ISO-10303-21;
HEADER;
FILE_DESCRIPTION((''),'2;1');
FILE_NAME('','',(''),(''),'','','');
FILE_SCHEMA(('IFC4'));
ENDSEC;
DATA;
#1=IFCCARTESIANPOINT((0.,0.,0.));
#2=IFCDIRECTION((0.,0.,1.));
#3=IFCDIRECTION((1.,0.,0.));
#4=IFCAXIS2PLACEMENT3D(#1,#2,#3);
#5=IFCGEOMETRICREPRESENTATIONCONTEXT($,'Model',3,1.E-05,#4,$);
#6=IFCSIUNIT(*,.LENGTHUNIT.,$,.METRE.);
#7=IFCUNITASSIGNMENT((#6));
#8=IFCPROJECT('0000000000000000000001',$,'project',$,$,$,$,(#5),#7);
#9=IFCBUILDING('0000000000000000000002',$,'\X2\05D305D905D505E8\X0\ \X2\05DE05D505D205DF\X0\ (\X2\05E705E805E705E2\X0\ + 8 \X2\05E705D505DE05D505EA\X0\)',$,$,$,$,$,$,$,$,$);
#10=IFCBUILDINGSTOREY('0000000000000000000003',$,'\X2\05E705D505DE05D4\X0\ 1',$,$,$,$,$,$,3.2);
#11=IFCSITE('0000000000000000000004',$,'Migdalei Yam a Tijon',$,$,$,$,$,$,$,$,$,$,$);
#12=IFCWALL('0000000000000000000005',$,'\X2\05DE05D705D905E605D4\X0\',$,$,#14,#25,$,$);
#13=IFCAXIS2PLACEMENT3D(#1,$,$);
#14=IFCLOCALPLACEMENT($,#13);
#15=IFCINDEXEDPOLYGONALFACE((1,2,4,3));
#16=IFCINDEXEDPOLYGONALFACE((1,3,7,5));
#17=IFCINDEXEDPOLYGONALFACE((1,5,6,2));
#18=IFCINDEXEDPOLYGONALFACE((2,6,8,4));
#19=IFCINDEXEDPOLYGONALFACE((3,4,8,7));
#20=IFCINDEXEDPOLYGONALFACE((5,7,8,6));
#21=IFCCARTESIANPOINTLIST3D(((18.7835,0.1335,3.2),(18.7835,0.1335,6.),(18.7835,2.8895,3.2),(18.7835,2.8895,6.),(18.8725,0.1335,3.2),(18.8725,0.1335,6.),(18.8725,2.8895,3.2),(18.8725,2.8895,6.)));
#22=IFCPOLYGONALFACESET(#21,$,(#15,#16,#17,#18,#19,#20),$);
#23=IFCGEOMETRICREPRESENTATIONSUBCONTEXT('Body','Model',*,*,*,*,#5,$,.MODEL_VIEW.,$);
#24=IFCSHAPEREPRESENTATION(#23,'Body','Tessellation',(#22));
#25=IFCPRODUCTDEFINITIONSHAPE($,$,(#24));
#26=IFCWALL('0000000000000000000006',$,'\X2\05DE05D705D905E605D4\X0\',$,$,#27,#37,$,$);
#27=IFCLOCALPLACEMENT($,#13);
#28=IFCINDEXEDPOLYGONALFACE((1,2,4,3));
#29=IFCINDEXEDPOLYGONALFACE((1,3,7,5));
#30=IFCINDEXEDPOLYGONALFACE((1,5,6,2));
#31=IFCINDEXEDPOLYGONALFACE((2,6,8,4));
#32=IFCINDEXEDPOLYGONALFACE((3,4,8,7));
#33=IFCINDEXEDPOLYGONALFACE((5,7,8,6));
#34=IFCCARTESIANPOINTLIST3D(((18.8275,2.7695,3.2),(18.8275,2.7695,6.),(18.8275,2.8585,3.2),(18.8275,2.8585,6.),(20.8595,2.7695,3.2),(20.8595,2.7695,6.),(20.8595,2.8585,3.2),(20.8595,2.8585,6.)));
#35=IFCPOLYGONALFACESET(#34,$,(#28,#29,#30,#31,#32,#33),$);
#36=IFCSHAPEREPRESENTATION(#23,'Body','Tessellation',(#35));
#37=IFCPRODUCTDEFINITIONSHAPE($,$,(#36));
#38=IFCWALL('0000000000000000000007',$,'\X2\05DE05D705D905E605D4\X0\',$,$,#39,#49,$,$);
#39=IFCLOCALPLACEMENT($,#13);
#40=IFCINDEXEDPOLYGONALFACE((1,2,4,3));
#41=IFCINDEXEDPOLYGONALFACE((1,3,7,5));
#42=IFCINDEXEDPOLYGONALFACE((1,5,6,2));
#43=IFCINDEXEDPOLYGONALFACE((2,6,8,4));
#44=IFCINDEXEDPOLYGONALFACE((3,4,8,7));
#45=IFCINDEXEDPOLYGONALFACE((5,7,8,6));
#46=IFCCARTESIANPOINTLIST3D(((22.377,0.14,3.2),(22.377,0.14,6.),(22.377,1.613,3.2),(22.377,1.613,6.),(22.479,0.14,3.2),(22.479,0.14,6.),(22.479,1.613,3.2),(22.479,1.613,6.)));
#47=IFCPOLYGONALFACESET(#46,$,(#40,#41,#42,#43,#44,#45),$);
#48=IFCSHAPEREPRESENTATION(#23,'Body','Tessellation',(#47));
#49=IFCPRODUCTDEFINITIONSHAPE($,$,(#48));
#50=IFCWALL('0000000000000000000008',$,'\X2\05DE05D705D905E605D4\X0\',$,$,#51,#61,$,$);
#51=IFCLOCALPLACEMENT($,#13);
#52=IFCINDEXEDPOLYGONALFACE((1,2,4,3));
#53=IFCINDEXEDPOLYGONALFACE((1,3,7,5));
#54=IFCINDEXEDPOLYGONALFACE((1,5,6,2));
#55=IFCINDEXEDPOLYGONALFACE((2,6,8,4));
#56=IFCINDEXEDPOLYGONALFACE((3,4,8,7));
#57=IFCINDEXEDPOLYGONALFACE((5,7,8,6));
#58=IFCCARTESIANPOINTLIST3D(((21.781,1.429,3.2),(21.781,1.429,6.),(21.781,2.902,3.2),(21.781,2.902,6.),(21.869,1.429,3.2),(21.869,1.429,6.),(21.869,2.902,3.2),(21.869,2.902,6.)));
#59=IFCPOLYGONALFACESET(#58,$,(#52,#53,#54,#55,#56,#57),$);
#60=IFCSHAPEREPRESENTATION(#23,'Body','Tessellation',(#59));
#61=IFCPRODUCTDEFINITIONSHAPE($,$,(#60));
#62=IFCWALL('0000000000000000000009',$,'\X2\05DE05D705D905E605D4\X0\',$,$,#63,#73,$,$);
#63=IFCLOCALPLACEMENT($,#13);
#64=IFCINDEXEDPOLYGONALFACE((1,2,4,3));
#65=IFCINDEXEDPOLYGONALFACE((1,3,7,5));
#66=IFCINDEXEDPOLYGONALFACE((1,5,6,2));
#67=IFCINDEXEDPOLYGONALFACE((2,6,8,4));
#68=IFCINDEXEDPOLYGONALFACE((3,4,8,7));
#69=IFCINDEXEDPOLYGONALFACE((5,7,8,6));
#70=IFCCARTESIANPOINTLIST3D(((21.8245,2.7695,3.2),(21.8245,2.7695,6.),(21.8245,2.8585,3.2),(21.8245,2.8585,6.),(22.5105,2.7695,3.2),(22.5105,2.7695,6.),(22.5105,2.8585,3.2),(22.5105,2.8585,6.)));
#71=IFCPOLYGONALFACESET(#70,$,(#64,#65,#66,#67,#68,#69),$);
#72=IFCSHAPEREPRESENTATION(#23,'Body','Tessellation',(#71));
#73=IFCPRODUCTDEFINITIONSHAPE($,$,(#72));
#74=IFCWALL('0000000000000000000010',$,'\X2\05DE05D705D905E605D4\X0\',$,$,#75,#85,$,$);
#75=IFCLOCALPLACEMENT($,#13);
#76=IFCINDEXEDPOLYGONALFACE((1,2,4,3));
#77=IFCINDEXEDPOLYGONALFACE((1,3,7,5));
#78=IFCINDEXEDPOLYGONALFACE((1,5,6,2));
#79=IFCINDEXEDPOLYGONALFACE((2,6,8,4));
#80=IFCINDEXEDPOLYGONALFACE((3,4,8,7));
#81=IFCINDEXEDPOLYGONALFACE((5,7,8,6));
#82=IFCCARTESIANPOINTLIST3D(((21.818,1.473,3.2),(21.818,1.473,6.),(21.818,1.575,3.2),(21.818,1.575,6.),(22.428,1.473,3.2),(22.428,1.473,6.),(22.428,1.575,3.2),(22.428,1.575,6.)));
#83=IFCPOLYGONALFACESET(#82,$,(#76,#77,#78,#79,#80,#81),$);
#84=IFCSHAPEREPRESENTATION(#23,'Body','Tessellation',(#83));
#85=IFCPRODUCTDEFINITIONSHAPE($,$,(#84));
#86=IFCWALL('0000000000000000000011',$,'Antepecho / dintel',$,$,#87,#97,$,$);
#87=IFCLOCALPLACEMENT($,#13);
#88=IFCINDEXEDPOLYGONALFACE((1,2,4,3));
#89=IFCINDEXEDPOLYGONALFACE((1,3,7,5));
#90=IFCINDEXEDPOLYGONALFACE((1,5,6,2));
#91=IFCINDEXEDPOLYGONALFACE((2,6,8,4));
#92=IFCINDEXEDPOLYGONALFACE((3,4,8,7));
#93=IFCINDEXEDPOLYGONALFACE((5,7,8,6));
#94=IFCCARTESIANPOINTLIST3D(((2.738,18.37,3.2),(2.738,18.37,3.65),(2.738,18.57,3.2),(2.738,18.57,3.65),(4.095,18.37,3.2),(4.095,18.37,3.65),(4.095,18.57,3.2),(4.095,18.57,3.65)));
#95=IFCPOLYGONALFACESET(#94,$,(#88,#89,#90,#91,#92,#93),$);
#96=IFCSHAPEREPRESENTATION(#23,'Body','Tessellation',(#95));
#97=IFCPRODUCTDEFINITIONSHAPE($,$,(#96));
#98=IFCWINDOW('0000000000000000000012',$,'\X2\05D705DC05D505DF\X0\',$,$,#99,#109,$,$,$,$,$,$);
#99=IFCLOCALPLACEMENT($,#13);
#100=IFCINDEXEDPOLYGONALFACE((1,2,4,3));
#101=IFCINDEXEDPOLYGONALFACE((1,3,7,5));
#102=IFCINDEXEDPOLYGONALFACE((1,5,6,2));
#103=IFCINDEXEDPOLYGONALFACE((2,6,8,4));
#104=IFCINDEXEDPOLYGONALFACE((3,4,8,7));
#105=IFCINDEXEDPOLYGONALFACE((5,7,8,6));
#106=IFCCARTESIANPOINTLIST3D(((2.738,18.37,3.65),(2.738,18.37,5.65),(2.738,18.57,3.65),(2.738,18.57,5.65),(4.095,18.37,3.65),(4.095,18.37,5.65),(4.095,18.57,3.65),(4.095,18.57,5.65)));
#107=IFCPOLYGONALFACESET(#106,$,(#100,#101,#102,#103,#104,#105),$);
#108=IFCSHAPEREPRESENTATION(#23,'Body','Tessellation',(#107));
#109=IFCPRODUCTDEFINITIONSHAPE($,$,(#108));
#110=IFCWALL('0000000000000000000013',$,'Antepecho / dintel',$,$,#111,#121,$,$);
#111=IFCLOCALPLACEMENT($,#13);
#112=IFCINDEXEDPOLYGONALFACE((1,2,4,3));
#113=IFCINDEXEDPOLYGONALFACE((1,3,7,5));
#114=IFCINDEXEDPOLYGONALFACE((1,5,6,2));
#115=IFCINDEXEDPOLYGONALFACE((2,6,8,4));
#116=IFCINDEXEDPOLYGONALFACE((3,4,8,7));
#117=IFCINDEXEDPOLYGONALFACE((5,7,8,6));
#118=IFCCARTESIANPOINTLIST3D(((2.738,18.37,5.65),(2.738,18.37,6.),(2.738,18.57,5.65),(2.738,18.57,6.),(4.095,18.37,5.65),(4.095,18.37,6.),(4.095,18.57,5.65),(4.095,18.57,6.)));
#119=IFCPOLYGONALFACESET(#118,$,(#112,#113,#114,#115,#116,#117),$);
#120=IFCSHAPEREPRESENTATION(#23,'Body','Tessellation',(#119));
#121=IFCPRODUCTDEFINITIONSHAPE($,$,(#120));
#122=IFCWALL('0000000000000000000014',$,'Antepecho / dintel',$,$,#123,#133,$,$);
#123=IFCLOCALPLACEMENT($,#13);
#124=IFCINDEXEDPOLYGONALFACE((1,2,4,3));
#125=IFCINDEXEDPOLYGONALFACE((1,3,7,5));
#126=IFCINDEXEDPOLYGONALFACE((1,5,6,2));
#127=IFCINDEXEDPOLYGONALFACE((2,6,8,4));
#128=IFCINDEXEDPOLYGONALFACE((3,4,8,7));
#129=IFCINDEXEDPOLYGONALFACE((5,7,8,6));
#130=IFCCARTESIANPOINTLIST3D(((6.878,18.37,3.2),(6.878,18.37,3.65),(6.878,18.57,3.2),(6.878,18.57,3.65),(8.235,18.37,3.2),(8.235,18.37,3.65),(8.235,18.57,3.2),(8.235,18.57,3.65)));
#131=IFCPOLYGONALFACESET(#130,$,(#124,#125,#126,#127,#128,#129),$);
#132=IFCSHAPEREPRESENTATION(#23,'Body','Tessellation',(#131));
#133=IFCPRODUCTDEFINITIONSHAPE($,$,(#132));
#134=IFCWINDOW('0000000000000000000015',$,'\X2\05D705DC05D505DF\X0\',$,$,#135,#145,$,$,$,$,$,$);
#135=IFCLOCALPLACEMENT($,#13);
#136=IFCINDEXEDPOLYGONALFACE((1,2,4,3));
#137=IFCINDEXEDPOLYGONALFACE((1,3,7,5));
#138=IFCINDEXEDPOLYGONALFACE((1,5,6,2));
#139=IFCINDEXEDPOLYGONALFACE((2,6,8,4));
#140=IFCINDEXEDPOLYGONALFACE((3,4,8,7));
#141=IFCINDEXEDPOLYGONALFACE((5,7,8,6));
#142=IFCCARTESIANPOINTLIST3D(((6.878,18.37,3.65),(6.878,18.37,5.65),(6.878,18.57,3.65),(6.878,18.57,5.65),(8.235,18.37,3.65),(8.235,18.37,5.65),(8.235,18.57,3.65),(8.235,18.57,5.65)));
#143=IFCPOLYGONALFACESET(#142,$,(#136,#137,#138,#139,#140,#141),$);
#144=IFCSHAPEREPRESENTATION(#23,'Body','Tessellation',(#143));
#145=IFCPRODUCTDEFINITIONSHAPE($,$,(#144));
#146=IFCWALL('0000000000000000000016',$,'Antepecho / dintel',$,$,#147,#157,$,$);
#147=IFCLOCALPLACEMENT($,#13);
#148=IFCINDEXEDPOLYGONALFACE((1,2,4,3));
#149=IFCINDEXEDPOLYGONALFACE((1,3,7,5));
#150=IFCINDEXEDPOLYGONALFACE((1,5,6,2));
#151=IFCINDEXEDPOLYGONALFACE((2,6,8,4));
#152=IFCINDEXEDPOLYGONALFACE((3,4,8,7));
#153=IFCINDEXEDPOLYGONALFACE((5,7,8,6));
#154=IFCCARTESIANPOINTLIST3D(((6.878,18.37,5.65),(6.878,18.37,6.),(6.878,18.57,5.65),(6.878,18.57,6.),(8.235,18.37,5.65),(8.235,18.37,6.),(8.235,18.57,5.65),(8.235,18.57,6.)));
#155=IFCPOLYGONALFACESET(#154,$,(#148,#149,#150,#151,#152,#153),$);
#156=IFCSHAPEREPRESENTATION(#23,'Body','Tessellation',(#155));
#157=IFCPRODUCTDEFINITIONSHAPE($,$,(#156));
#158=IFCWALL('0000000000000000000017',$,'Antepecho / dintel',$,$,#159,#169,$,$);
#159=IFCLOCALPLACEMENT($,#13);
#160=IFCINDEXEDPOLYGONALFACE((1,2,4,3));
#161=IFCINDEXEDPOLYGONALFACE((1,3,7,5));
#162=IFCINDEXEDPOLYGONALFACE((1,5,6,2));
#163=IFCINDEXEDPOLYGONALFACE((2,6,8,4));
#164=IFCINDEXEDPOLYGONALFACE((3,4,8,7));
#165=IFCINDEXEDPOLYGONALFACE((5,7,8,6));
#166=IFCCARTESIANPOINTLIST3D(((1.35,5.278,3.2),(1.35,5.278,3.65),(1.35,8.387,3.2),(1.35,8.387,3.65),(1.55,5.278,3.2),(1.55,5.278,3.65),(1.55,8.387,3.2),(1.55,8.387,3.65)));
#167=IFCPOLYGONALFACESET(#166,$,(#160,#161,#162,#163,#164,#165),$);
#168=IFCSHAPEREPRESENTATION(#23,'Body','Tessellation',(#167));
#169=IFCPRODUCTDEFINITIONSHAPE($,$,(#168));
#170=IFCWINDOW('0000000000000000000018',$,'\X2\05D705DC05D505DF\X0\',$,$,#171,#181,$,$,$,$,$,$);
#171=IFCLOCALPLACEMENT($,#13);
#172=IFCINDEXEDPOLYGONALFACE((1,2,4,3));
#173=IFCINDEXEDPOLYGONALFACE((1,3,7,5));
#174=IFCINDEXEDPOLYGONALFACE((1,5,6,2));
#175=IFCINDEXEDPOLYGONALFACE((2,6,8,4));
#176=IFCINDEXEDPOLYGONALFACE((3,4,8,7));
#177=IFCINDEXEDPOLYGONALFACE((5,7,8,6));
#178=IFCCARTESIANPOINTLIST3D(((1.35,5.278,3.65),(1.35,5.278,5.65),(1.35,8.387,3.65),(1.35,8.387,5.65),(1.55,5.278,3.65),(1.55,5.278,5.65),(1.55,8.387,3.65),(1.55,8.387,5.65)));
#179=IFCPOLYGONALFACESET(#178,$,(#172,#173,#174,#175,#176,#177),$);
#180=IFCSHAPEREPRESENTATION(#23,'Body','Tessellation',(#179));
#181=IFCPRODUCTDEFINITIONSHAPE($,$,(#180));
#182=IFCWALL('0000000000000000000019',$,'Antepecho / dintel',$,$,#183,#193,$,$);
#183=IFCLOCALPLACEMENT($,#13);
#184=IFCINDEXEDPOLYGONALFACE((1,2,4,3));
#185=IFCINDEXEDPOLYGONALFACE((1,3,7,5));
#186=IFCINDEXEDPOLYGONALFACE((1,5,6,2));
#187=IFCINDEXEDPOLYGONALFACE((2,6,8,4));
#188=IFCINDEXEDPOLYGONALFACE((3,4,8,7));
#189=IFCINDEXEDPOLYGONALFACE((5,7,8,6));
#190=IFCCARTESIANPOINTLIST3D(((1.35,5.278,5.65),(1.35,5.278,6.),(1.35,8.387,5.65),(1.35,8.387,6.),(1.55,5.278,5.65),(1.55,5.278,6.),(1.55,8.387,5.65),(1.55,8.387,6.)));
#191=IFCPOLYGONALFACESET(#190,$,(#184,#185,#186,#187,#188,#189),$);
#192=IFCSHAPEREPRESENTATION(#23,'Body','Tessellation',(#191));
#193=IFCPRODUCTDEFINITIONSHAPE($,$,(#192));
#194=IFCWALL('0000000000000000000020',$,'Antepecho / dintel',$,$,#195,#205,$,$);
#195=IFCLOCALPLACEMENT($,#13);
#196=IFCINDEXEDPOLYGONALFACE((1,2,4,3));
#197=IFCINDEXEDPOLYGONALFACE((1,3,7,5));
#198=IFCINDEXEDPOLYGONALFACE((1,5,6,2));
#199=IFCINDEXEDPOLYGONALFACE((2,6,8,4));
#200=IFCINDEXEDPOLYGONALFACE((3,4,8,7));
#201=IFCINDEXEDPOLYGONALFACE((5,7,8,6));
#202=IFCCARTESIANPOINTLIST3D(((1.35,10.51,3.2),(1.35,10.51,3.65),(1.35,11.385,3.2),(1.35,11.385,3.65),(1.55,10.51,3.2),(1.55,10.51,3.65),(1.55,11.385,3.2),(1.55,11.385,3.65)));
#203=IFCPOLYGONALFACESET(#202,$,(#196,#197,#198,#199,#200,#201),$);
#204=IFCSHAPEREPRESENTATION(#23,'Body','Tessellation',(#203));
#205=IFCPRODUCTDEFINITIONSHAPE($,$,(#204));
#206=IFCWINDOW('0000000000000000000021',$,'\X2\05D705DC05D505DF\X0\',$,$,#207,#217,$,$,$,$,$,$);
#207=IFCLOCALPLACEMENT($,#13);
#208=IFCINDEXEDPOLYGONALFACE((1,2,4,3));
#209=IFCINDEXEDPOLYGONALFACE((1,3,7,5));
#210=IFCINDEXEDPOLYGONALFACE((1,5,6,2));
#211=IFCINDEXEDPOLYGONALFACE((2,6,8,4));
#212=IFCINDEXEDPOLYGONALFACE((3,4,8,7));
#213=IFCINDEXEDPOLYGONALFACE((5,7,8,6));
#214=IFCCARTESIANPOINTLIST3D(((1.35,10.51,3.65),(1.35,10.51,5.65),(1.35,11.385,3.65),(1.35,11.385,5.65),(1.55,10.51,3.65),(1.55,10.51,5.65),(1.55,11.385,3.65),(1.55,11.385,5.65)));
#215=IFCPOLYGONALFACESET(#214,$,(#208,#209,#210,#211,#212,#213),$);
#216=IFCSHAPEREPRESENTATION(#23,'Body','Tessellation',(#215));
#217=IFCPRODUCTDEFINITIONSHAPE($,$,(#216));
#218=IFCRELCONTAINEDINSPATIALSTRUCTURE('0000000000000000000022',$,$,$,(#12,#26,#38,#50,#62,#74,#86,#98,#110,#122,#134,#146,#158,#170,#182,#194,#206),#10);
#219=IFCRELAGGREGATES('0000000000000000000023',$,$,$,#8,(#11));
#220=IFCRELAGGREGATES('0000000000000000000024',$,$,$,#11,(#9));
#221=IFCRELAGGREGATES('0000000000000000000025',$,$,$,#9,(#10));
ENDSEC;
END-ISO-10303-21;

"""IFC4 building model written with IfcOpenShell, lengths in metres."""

from ifc_helpers import new_model, si_unit, frame, origin_with_axes, context, subcontext, project, spatial, line, indexed_curve, outline, extrude, element, save


model = new_model("IFC4")

# Units and contexts
model_context = context("Model", 3, precision=1e-05, world=origin_with_axes())
body_context = subcontext(model_context, "Body", "Model", "MODEL_VIEW")
ifc_project = project(units=[si_unit("LENGTHUNIT", "METRE")], contexts=[model_context])

# Site, building, storey
site = spatial("IfcSite", under=ifc_project, Name="Migdalei Yam a Tijon")
building = spatial("IfcBuilding", under=site, Name="דיור מוגן (קרקע + 8 קומות)")
storey = spatial("IfcBuildingStorey", under=building, Name="קומה 1", Elevation=3.2)

# Walls
element("IfcWall", 1, inside=storey, Name="מחיצה", context=body_context, shape_type="SweptSolid", body=[
    extrude(outline(indexed_curve([(0.0, 0.0), (0.089, 0.0), (0.089, 2.756), (0.0, 2.756)], segments=[line(1, 2, 3, 4, 1)])), frame((18.7835, 0.1335, 3.2), z_axis=(0.0, 0.0, 1.0), x_axis=(1.0, 0.0, 0.0)), (0.0, 0.0, 1.0), 2.8),
])
element("IfcWall", 2, inside=storey, Name="מחיצה", context=body_context, shape_type="SweptSolid", body=[
    extrude(outline(indexed_curve([(0.0, 0.0), (2.032, 0.0), (2.032, 0.089), (0.0, 0.089)], segments=[line(1, 2, 3, 4, 1)])), frame((18.8275, 2.7695, 3.2), z_axis=(0.0, 0.0, 1.0), x_axis=(1.0, 0.0, 0.0)), (0.0, 0.0, 1.0), 2.8),
])
element("IfcWall", 3, inside=storey, Name="מחיצה", context=body_context, shape_type="SweptSolid", body=[
    extrude(outline(indexed_curve([(0.0, 0.0), (0.102, 0.0), (0.102, 1.473), (0.0, 1.473)], segments=[line(1, 2, 3, 4, 1)])), frame((22.377, 0.14, 3.2), z_axis=(0.0, 0.0, 1.0), x_axis=(1.0, 0.0, 0.0)), (0.0, 0.0, 1.0), 2.8),
])
element("IfcWall", 4, inside=storey, Name="מחיצה", context=body_context, shape_type="SweptSolid", body=[
    extrude(outline(indexed_curve([(0.0, 0.0), (0.088, 0.0), (0.088, 1.473), (0.0, 1.473)], segments=[line(1, 2, 3, 4, 1)])), frame((21.781, 1.429, 3.2), z_axis=(0.0, 0.0, 1.0), x_axis=(1.0, 0.0, 0.0)), (0.0, 0.0, 1.0), 2.8),
])
element("IfcWall", 5, inside=storey, Name="מחיצה", context=body_context, shape_type="SweptSolid", body=[
    extrude(outline(indexed_curve([(0.0, 0.0), (0.686, 0.0), (0.686, 0.089), (0.0, 0.089)], segments=[line(1, 2, 3, 4, 1)])), frame((21.8245, 2.7695, 3.2), z_axis=(0.0, 0.0, 1.0), x_axis=(1.0, 0.0, 0.0)), (0.0, 0.0, 1.0), 2.8),
])
element("IfcWall", 6, inside=storey, Name="מחיצה", context=body_context, shape_type="SweptSolid", body=[
    extrude(outline(indexed_curve([(0.0, 0.0), (0.61, 0.0), (0.61, 0.102), (0.0, 0.102)], segments=[line(1, 2, 3, 4, 1)])), frame((21.818, 1.473, 3.2), z_axis=(0.0, 0.0, 1.0), x_axis=(1.0, 0.0, 0.0)), (0.0, 0.0, 1.0), 2.8),
])
element("IfcWall", 7, inside=storey, Name="Antepecho / dintel", context=body_context, shape_type="SweptSolid", body=[
    extrude(outline(indexed_curve([(0.0, 0.0), (1.357, 0.0), (1.357, 0.2), (0.0, 0.2)], segments=[line(1, 2, 3, 4, 1)])), frame((2.738, 18.37, 3.2), z_axis=(0.0, 0.0, 1.0), x_axis=(1.0, 0.0, 0.0)), (0.0, 0.0, 1.0), 0.45),
])

# Window
element("IfcWindow", 8, inside=storey, Name="חלון", context=body_context, shape_type="SweptSolid", body=[
    extrude(outline(indexed_curve([(0.0, 0.0), (1.357, 0.0), (1.357, 0.2), (0.0, 0.2)], segments=[line(1, 2, 3, 4, 1)])), frame((2.738, 18.37, 3.65), z_axis=(0.0, 0.0, 1.0), x_axis=(1.0, 0.0, 0.0)), (0.0, 0.0, 1.0), 2.0),
])

# Walls
element("IfcWall", 9, inside=storey, Name="Antepecho / dintel", context=body_context, shape_type="SweptSolid", body=[
    extrude(outline(indexed_curve([(0.0, 0.0), (1.357, 0.0), (1.357, 0.2), (0.0, 0.2)], segments=[line(1, 2, 3, 4, 1)])), frame((2.738, 18.37, 5.65), z_axis=(0.0, 0.0, 1.0), x_axis=(1.0, 0.0, 0.0)), (0.0, 0.0, 1.0), 0.35),
])
element("IfcWall", 10, inside=storey, Name="Antepecho / dintel", context=body_context, shape_type="SweptSolid", body=[
    extrude(outline(indexed_curve([(0.0, 0.0), (1.357, 0.0), (1.357, 0.2), (0.0, 0.2)], segments=[line(1, 2, 3, 4, 1)])), frame((6.878, 18.37, 3.2), z_axis=(0.0, 0.0, 1.0), x_axis=(1.0, 0.0, 0.0)), (0.0, 0.0, 1.0), 0.45),
])

# Window
element("IfcWindow", 11, inside=storey, Name="חלון", context=body_context, shape_type="SweptSolid", body=[
    extrude(outline(indexed_curve([(0.0, 0.0), (1.357, 0.0), (1.357, 0.2), (0.0, 0.2)], segments=[line(1, 2, 3, 4, 1)])), frame((6.878, 18.37, 3.65), z_axis=(0.0, 0.0, 1.0), x_axis=(1.0, 0.0, 0.0)), (0.0, 0.0, 1.0), 2.0),
])

# Walls
element("IfcWall", 12, inside=storey, Name="Antepecho / dintel", context=body_context, shape_type="SweptSolid", body=[
    extrude(outline(indexed_curve([(0.0, 0.0), (1.357, 0.0), (1.357, 0.2), (0.0, 0.2)], segments=[line(1, 2, 3, 4, 1)])), frame((6.878, 18.37, 5.65), z_axis=(0.0, 0.0, 1.0), x_axis=(1.0, 0.0, 0.0)), (0.0, 0.0, 1.0), 0.35),
])
element("IfcWall", 13, inside=storey, Name="Antepecho / dintel", context=body_context, shape_type="SweptSolid", body=[
    extrude(outline(indexed_curve([(0.0, 0.0), (0.2, 0.0), (0.2, 3.109), (0.0, 3.109)], segments=[line(1, 2, 3, 4, 1)])), frame((1.35, 5.278, 3.2), z_axis=(0.0, 0.0, 1.0), x_axis=(1.0, 0.0, 0.0)), (0.0, 0.0, 1.0), 0.45),
])

# Window
element("IfcWindow", 14, inside=storey, Name="חלון", context=body_context, shape_type="SweptSolid", body=[
    extrude(outline(indexed_curve([(0.0, 0.0), (0.2, 0.0), (0.2, 3.109), (0.0, 3.109)], segments=[line(1, 2, 3, 4, 1)])), frame((1.35, 5.278, 3.65), z_axis=(0.0, 0.0, 1.0), x_axis=(1.0, 0.0, 0.0)), (0.0, 0.0, 1.0), 2.0),
])

# Walls
element("IfcWall", 15, inside=storey, Name="Antepecho / dintel", context=body_context, shape_type="SweptSolid", body=[
    extrude(outline(indexed_curve([(0.0, 0.0), (0.2, 0.0), (0.2, 3.109), (0.0, 3.109)], segments=[line(1, 2, 3, 4, 1)])), frame((1.35, 5.278, 5.65), z_axis=(0.0, 0.0, 1.0), x_axis=(1.0, 0.0, 0.0)), (0.0, 0.0, 1.0), 0.35),
])
element("IfcWall", 16, inside=storey, Name="Antepecho / dintel", context=body_context, shape_type="SweptSolid", body=[
    extrude(outline(indexed_curve([(0.0, 0.0), (0.2, 0.0), (0.2, 0.875), (0.0, 0.875)], segments=[line(1, 2, 3, 4, 1)])), frame((1.35, 10.51, 3.2), z_axis=(0.0, 0.0, 1.0), x_axis=(1.0, 0.0, 0.0)), (0.0, 0.0, 1.0), 0.45),
])

# Window
element("IfcWindow", 17, inside=storey, Name="חלון", context=body_context, shape_type="SweptSolid", body=[
    extrude(outline(indexed_curve([(0.0, 0.0), (0.2, 0.0), (0.2, 0.875), (0.0, 0.875)], segments=[line(1, 2, 3, 4, 1)])), frame((1.35, 10.51, 3.65), z_axis=(0.0, 0.0, 1.0), x_axis=(1.0, 0.0, 0.0)), (0.0, 0.0, 1.0), 2.0),
])

save(model, "model.ifc")
